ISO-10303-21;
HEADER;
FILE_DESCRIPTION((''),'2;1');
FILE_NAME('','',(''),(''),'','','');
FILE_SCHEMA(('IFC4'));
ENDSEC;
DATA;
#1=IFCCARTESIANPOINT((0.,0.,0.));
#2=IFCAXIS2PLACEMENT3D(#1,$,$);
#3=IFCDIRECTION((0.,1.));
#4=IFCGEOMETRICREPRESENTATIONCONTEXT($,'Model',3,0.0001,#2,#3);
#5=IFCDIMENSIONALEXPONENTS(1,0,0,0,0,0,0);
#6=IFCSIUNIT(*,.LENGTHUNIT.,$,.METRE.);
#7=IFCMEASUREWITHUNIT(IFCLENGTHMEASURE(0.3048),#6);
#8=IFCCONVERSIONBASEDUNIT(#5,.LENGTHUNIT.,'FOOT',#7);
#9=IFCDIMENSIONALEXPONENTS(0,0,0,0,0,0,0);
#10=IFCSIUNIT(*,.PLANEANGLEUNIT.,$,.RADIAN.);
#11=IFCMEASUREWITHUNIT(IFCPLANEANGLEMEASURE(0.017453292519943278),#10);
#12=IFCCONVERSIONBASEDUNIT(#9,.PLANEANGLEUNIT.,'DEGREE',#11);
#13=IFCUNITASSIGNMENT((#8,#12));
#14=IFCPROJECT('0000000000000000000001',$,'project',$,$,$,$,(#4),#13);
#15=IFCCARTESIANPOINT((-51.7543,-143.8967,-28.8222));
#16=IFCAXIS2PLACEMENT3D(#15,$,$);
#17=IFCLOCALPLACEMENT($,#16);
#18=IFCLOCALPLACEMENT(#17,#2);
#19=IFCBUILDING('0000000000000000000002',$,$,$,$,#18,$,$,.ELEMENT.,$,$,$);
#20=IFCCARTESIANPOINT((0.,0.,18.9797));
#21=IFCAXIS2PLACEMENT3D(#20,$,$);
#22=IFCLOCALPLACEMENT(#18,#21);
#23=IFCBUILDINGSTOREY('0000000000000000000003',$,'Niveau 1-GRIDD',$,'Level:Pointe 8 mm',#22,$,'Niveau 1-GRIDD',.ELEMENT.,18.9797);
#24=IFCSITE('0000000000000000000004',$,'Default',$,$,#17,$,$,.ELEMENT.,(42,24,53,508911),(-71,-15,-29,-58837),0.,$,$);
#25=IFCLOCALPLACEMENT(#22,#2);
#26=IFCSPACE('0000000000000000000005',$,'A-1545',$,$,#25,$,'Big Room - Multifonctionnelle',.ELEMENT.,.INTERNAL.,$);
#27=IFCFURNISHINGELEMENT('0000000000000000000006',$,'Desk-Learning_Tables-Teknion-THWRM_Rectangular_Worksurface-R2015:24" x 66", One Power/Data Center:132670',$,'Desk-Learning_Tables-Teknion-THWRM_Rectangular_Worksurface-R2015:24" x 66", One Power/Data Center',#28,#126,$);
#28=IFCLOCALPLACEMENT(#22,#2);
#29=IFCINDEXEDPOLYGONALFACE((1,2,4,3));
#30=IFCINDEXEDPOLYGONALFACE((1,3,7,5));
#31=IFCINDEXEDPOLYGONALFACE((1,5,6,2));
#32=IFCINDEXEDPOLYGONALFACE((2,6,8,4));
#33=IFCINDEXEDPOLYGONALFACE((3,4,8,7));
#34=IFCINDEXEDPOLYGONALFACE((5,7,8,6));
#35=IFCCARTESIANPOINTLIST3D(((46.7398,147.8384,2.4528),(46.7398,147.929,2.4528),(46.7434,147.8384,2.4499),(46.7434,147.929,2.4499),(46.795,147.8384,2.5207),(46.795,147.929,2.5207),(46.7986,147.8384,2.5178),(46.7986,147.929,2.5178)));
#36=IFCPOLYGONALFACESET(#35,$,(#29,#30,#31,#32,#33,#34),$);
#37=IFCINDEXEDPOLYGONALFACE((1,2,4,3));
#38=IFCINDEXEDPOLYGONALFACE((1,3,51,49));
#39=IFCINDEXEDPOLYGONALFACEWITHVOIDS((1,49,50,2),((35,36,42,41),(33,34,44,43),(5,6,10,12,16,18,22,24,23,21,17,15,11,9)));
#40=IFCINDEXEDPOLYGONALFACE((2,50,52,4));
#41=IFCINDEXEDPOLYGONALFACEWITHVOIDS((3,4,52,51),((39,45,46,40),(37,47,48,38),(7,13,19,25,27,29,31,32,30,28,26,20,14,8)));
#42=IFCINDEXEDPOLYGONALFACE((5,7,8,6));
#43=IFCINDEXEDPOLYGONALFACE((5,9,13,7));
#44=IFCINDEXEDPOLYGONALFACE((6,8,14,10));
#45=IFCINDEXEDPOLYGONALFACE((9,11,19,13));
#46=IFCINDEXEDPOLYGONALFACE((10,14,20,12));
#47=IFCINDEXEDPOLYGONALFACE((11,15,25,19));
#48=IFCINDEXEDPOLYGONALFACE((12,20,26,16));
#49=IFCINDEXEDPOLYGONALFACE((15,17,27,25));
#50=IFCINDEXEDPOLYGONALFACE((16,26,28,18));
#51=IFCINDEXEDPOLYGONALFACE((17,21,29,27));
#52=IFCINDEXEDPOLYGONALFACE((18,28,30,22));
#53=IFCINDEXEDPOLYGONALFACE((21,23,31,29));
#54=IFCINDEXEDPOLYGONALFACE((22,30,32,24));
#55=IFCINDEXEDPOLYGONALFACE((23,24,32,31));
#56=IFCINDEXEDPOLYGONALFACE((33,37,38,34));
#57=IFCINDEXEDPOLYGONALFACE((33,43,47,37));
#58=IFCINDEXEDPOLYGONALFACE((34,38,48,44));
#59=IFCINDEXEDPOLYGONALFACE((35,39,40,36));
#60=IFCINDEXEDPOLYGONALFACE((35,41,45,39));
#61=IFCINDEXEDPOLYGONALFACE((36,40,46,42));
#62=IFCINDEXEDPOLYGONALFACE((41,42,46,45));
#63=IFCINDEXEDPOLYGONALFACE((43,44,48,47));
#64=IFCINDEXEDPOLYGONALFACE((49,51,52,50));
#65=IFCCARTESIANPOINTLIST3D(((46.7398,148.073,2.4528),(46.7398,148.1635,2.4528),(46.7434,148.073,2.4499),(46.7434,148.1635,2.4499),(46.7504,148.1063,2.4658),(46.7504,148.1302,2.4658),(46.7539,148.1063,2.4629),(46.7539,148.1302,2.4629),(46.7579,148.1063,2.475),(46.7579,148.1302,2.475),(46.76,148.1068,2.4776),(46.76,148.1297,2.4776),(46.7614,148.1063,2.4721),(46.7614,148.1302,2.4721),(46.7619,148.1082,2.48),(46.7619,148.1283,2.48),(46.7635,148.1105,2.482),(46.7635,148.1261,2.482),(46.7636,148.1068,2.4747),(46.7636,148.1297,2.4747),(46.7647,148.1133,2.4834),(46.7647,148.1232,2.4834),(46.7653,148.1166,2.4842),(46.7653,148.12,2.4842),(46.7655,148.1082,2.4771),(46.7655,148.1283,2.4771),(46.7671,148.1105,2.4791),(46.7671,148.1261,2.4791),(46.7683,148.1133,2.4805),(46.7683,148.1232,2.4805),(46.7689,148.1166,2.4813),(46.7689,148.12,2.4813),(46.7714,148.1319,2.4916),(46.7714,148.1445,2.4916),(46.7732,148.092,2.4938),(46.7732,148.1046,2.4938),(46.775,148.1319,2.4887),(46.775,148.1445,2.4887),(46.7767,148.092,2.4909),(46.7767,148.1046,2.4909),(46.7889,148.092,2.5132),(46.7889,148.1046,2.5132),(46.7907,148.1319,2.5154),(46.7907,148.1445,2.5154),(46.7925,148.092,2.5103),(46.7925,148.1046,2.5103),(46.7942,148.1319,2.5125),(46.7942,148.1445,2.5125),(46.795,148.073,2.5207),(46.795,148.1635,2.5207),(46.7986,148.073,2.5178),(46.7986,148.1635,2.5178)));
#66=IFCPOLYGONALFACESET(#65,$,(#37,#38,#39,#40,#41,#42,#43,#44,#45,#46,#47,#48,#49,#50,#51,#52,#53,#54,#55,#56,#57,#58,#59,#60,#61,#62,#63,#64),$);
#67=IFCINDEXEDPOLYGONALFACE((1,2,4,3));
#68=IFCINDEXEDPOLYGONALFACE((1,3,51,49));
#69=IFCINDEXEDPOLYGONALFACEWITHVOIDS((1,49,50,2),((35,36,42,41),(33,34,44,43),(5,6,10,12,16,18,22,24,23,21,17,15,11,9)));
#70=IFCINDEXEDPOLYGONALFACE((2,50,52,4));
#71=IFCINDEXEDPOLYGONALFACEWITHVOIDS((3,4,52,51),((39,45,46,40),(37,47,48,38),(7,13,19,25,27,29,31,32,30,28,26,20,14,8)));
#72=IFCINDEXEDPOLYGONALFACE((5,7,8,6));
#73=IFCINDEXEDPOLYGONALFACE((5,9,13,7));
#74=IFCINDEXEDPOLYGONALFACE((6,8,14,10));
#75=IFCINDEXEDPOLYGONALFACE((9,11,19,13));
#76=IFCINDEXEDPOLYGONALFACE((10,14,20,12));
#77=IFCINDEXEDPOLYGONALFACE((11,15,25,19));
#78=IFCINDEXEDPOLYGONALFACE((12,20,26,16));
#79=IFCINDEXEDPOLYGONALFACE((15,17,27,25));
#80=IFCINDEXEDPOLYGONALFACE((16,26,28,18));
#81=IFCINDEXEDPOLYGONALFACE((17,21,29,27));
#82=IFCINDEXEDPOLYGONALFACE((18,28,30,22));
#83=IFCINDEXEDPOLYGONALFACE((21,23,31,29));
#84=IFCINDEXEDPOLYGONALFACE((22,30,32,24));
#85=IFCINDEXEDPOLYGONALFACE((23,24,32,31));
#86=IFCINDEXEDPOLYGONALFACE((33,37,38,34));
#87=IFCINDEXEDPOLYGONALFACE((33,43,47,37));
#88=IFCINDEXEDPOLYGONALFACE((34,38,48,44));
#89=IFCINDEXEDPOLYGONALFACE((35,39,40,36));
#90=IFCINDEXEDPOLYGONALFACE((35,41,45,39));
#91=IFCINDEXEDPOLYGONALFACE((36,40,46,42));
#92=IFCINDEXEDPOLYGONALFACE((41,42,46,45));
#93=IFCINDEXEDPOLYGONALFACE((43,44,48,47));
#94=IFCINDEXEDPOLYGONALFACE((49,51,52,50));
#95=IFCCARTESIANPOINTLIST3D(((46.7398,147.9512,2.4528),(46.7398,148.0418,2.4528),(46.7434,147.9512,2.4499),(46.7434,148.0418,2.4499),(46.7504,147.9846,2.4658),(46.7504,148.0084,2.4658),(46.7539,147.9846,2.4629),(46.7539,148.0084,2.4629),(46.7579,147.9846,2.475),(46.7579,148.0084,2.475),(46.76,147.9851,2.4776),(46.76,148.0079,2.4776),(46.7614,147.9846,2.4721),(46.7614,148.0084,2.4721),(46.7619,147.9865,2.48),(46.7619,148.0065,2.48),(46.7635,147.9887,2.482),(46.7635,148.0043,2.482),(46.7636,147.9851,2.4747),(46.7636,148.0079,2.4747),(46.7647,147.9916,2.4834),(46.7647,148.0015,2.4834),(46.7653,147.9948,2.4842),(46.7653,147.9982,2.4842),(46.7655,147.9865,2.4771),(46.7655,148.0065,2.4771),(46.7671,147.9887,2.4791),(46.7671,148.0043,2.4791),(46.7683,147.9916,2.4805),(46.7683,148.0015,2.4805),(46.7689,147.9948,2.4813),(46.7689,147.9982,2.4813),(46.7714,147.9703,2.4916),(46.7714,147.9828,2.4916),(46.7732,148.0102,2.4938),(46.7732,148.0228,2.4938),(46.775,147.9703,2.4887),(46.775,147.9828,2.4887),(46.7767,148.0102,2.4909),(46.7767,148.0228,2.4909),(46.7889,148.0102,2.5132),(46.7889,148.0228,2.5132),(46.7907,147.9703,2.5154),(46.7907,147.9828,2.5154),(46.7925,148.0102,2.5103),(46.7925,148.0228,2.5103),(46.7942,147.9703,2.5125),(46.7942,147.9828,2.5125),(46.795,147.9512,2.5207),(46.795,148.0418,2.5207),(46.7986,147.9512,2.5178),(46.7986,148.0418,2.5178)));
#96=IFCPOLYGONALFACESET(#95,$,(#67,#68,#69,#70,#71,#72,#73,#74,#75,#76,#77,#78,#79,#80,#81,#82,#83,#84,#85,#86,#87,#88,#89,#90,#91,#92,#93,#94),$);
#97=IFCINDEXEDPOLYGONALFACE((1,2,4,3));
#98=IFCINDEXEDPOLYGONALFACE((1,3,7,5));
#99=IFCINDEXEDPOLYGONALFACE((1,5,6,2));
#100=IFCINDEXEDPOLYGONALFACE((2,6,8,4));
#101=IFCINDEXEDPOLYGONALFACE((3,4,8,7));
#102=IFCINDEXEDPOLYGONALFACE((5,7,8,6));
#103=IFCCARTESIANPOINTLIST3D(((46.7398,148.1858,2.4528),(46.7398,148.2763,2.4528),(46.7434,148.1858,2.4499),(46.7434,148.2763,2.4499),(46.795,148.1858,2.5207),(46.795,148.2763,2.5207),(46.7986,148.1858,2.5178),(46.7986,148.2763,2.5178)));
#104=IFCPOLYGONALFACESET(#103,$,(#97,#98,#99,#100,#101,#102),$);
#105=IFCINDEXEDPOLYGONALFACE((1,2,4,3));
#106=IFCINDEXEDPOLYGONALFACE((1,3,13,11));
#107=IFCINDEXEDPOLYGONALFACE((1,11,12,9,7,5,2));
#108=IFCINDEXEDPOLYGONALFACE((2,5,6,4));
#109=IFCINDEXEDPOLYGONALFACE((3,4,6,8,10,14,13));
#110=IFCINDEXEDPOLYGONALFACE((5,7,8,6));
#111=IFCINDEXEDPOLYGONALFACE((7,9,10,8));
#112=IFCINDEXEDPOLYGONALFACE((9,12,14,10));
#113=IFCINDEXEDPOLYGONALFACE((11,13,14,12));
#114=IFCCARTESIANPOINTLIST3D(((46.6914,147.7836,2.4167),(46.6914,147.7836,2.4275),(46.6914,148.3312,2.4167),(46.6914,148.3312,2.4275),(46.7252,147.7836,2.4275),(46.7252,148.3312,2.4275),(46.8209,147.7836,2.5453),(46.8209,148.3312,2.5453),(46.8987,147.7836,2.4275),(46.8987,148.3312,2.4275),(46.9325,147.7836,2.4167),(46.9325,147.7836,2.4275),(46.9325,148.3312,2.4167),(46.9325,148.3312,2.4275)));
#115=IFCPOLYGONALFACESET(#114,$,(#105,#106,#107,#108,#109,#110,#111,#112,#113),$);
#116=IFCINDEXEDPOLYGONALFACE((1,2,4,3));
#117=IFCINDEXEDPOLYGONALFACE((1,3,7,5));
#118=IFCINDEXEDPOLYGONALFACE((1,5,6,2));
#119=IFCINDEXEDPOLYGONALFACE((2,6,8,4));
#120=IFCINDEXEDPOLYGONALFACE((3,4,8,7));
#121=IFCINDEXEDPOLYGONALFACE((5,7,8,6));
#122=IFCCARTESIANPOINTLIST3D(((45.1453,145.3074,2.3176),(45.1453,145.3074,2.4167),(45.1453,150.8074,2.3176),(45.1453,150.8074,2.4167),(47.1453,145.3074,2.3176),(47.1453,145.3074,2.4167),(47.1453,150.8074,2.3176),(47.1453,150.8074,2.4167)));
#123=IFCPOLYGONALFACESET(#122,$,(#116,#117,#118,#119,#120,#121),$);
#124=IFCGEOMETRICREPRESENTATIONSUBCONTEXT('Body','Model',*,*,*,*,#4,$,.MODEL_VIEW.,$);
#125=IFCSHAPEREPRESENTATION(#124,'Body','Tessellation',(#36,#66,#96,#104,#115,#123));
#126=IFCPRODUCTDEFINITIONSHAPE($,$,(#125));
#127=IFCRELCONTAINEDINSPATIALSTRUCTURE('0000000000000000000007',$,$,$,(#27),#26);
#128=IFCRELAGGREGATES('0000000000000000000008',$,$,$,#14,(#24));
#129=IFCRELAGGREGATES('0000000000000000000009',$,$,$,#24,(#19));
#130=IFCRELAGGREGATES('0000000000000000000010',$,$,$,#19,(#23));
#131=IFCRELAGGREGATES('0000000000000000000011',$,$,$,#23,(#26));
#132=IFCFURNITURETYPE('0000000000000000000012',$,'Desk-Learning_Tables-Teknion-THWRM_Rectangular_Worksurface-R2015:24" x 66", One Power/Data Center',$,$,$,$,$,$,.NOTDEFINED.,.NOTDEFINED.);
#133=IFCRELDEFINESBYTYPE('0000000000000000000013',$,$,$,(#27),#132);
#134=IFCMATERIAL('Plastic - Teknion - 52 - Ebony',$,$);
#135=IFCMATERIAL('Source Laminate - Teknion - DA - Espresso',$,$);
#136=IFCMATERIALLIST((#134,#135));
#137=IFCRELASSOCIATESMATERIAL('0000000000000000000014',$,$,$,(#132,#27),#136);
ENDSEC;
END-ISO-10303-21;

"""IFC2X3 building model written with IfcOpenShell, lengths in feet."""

from ifc_helpers import new_model, entity, si_unit, converted_unit, direction, frame, frame_2d, origin, place, context, subcontext, project, spatial, polyline, circle_curve, parameter, trimmed, segment, composite_curve, rectangle, outline, extrude, source, transform, mapped, material, material_list, type_object, type_shapes, element, save


model = new_model("IFC2X3")

# Units and contexts
model_context = context("Model", 3, precision=0.0001, world=origin(), true_north=direction((0.0, 1.0)))
body_context = subcontext(model_context, "Body", "Model", "MODEL_VIEW")
ifc_project = project(units=[converted_unit("LENGTHUNIT", "FOOT", entity("IfcLengthMeasure", 0.3048), si_unit("LENGTHUNIT", "METRE"), dimensions=[1, 0, 0, 0, 0, 0, 0]), converted_unit("PLANEANGLEUNIT", "DEGREE", entity("IfcPlaneAngleMeasure", 0.017453292519943278), si_unit("PLANEANGLEUNIT", "RADIAN"), dimensions=[0, 0, 0, 0, 0, 0, 0])], contexts=[model_context])

# Site, building, storey
site_placement = place(None, frame((-51.7543, -143.8967, -28.8222)))
site = spatial("IfcSite", under=ifc_project, at=site_placement, Name="Default", CompositionType="ELEMENT", RefLatitude=(42, 24, 53, 508911), RefLongitude=(-71, -15, -29, -58837), RefElevation=0.0)
building_placement = place(site_placement, origin())
building = spatial("IfcBuilding", under=site, at=building_placement, CompositionType="ELEMENT")
storey_placement = place(building_placement, frame((0.0, 0.0, 18.9797)))
storey = spatial("IfcBuildingStorey", under=building, at=storey_placement, Name="Niveau 1-GRIDD", ObjectType="Level:Pointe 8 mm", LongName="Niveau 1-GRIDD", CompositionType="ELEMENT", Elevation=18.9797)

# Shared definitions
space_1_placement = place(storey_placement, origin())
space_1 = spatial("IfcSpace", under=storey, at=space_1_placement, Name="A-1545", LongName="Big Room - Multifonctionnelle", CompositionType="ELEMENT", InteriorOrExteriorSpace="INTERNAL")

# Furnishing element
ifc_material_1 = material(Name="Plastic - Teknion - 52 - Ebony")
ifc_material_2 = material(Name="Source Laminate - Teknion - DA - Espresso")
ifc_material_list_1 = material_list([ifc_material_1, ifc_material_2])
furniture_type_1 = type_object("IfcFurnitureType", Name="Desk-Learning_Tables-Teknion-THWRM_Rectangular_Worksurface-R2015:24\" x 66\", One Power/Data Center", AssemblyPlace="NOTDEFINED", material=ifc_material_list_1)
shared_shape_1 = source(origin(), body_context, "Body", "SweptSolid", [
    extrude(rectangle(XDim=0.0875, YDim=0.0046, at=frame_2d((0.0, 0.0), x_axis=(0.0, 1.0))), frame((0.1284, 0.6239, 2.4853), z_axis=(1.0, 0.0, 0.0), x_axis=(0.0, 0.776046, -0.630676)), (0.0, 0.0, 1.0), 0.0906),
    extrude(outline(polyline([(-0.0453, -0.0438), (0.0453, -0.0438), (0.0453, 0.0438), (-0.0453, 0.0438), (-0.0453, -0.0438)]), holes=[polyline([(-0.0262, -0.0063), (-0.0137, -0.0063), (-0.0137, -0.0369), (-0.0262, -0.0369), (-0.0262, -0.0063)]), polyline([(0.0137, -0.0341), (0.0137, -0.0091), (0.0262, -0.0091), (0.0262, -0.0341), (0.0137, -0.0341)]), composite_curve([segment(polyline([(-0.0119, 0.027), (0.0119, 0.027)]), True, "CONTINUOUS"), segment(polyline([(0.0119, 0.027), (0.0119, 0.0151)]), True, "CONTINUOUS"), segment(trimmed(circle_curve(frame_2d((0.0, 0.0151), x_axis=(0.0, -1.0)), 0.0119), [parameter(270.0)], [parameter(90.0)], True, "PARAMETER"), False, "CONTINUOUS"), segment(polyline([(-0.0119, 0.0151), (-0.0119, 0.027)]), True, "CONTINUOUS")], self_intersect=False)]), frame((-0.0609, 0.6221, 2.4867), z_axis=(0.0, 0.776046, -0.630676), x_axis=(1.0, 0.0, 0.0)), (0.0, 0.0, 1.0), 0.0046),
    extrude(outline(polyline([(-0.0438, -0.0453), (0.0438, -0.0453), (0.0438, 0.0453), (-0.0438, 0.0453), (-0.0438, -0.0453)]), holes=[polyline([(-0.0063, -0.0262), (-0.0369, -0.0262), (-0.0369, -0.0137), (-0.0063, -0.0137), (-0.0063, -0.0262)]), polyline([(-0.0341, 0.0137), (-0.0341, 0.0262), (-0.0091, 0.0262), (-0.0091, 0.0137), (-0.0341, 0.0137)]), composite_curve([segment(polyline([(0.027, -0.0119), (0.0151, -0.0119)]), True, "CONTINUOUS"), segment(trimmed(circle_curve(frame_2d((0.0151, 0.0), x_axis=(-1.0, 0.0)), 0.0119), [parameter(270.0)], [parameter(90.0)], True, "PARAMETER"), False, "CONTINUOUS"), segment(polyline([(0.0151, 0.0119), (0.027, 0.0119)]), True, "CONTINUOUS"), segment(polyline([(0.027, 0.0119), (0.027, -0.0119)]), True, "CONTINUOUS")], self_intersect=False)]), frame((0.0609, 0.6221, 2.4867), z_axis=(0.0, 0.776046, -0.630676), x_axis=(0.0, -0.630676, -0.776046)), (0.0, 0.0, 1.0), 0.0046),
    extrude(rectangle(XDim=0.0875, YDim=0.0046, at=frame_2d((0.0, 0.0), x_axis=(0.0, 1.0))), frame((-0.219, 0.6239, 2.4853), z_axis=(1.0, 0.0, 0.0), x_axis=(0.0, 0.776046, -0.630676)), (0.0, 0.0, 1.0), 0.0906),
    extrude(outline(polyline([(-0.0586, -0.0638), (0.0826, -0.0638), (0.0371, 0.0811), (0.0557, 0.1093), (0.0467, 0.1152), (-0.0862, -0.086), (-0.0772, -0.092), (-0.0586, -0.0638)])), frame((-0.2738, 0.6679, 2.4412), z_axis=(1.0, 0.0, 0.0), x_axis=(0.0, -0.551103, 0.834437)), (0.0, 0.0, 1.0), 0.5475),
    extrude(rectangle(XDim=5.5, YDim=2.0, at=frame_2d((0.0, 0.0), x_axis=(1.0, 0.0))), frame((0.0, 0.0, 2.3176), z_axis=(0.0, 0.0, 1.0), x_axis=(-1.0, 0.0, 0.0)), (0.0, 0.0, 1.0), 0.0991),
])
type_shapes(furniture_type_1, [shared_shape_1])
for number, where, z_axis, x_axis, name in (
    (1, (46.1453, 148.0574, 0.0), (0.0, 0.0, 1.0), (0.0, -1.0, 0.0), "Desk-Learning_Tables-Teknion-THWRM_Rectangular_Worksurface-R2015:24\" x 66\", One Power/Data Center:132670"),
):
    element("IfcFurnishingElement", number, at=place(space_1_placement, frame(where, z_axis=z_axis, x_axis=x_axis)), inside=space_1, type_object=furniture_type_1, material=ifc_material_list_1, Name=name, ObjectType="Desk-Learning_Tables-Teknion-THWRM_Rectangular_Worksurface-R2015:24\" x 66\", One Power/Data Center", context=body_context, shape_type="MappedRepresentation", body=[
        mapped(shared_shape_1, transform((0.0, 0.0, 0.0), scale=1.0)),
    ])

save(model, "model.ifc")
